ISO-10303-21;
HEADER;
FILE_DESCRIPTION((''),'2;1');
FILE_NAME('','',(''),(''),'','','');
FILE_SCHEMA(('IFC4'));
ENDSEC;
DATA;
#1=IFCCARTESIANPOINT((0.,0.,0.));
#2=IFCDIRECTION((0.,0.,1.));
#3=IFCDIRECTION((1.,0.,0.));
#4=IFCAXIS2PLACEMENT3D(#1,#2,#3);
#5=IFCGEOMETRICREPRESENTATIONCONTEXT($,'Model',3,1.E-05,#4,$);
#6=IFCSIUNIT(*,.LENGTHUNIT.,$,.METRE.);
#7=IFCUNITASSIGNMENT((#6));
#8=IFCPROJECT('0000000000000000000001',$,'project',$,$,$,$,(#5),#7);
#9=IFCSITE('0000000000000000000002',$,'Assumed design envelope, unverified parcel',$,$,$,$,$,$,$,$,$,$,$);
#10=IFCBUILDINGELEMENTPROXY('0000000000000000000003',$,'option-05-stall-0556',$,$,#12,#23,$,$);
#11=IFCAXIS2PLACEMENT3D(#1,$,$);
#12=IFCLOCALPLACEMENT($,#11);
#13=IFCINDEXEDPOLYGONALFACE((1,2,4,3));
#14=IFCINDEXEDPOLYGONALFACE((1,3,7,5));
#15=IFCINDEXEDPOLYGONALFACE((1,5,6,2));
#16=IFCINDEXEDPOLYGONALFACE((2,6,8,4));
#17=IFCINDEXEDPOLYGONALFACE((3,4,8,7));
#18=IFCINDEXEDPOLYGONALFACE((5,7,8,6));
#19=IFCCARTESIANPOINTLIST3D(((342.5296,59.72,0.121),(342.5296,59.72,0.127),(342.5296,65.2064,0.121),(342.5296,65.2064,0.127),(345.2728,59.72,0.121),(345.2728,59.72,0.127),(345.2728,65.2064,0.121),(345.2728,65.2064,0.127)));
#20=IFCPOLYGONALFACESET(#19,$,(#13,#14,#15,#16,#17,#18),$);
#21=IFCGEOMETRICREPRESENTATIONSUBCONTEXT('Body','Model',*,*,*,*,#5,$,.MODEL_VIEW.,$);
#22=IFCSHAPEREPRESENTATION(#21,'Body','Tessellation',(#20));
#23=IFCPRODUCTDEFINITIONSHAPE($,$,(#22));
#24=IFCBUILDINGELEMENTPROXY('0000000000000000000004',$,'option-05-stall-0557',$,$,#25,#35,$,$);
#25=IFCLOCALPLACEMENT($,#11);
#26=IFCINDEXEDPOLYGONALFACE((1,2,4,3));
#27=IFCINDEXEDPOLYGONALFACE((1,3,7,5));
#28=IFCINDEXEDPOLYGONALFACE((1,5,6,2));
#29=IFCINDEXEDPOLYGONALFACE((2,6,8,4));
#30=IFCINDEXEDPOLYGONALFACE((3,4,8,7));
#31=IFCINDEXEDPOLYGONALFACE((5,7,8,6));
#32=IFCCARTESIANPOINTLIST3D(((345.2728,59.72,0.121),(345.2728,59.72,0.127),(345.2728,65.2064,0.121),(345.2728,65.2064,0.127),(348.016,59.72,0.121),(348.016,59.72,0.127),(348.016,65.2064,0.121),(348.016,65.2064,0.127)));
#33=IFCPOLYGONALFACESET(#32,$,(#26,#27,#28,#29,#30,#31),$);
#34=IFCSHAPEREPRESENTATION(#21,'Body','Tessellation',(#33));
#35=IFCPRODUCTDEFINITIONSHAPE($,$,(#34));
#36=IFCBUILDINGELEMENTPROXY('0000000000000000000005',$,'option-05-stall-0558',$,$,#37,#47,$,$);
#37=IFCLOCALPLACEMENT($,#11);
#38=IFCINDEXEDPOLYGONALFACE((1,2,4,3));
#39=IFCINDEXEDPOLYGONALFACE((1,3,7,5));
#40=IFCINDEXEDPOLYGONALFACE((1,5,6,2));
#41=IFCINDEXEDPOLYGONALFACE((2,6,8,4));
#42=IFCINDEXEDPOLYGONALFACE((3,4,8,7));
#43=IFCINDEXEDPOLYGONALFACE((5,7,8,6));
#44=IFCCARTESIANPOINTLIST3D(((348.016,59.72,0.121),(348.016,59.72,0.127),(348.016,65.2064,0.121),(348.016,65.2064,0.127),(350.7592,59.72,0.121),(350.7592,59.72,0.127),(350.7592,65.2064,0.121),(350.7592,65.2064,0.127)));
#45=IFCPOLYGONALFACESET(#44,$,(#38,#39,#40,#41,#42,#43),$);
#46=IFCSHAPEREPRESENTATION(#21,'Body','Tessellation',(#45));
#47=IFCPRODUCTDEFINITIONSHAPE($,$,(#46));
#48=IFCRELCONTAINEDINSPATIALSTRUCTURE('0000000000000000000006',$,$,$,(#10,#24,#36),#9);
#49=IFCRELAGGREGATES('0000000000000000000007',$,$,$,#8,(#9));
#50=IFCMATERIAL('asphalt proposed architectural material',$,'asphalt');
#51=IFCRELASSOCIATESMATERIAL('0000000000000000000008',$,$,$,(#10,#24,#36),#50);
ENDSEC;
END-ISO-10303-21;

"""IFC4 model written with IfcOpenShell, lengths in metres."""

from ifc_helpers import new_model, si_unit, frame, origin_with_axes, place, context, subcontext, project, spatial, rectangle, extrude, material, element, save


model = new_model("IFC4")

# Units and contexts
model_context = context("Model", 3, precision=1e-05, world=origin_with_axes())
body_context = subcontext(model_context, "Body", "Model", "MODEL_VIEW")
ifc_project = project(units=[si_unit("LENGTHUNIT", "METRE")], contexts=[model_context])

# Site
site = spatial("IfcSite", under=ifc_project, Name="Assumed design envelope, unverified parcel")

# Building element proxies
ifc_material = material(Name="asphalt proposed architectural material", Category="asphalt")
for number, where, z_axis, x_axis, name in (
    (1, (343.9012, 62.4632, 0.121), (0.0, 0.0, 1.0), (1.0, 0.0, 0.0), "option-05-stall-0556"),
    (2, (346.6444, 62.4632, 0.121), (0.0, 0.0, 1.0), (1.0, 0.0, 0.0), "option-05-stall-0557"),
    (3, (349.3876, 62.4632, 0.121), (0.0, 0.0, 1.0), (1.0, 0.0, 0.0), "option-05-stall-0558"),
):
    element("IfcBuildingElementProxy", number, at=place(None, frame(where, z_axis=z_axis, x_axis=x_axis)), inside=site, material=ifc_material, Name=name, context=body_context, shape_type="SweptSolid", body=[
        extrude(rectangle(XDim=2.7432, YDim=5.4864), origin_with_axes(), (0.0, 0.0, 1.0), 0.006),
    ])

save(model, "model.ifc")
